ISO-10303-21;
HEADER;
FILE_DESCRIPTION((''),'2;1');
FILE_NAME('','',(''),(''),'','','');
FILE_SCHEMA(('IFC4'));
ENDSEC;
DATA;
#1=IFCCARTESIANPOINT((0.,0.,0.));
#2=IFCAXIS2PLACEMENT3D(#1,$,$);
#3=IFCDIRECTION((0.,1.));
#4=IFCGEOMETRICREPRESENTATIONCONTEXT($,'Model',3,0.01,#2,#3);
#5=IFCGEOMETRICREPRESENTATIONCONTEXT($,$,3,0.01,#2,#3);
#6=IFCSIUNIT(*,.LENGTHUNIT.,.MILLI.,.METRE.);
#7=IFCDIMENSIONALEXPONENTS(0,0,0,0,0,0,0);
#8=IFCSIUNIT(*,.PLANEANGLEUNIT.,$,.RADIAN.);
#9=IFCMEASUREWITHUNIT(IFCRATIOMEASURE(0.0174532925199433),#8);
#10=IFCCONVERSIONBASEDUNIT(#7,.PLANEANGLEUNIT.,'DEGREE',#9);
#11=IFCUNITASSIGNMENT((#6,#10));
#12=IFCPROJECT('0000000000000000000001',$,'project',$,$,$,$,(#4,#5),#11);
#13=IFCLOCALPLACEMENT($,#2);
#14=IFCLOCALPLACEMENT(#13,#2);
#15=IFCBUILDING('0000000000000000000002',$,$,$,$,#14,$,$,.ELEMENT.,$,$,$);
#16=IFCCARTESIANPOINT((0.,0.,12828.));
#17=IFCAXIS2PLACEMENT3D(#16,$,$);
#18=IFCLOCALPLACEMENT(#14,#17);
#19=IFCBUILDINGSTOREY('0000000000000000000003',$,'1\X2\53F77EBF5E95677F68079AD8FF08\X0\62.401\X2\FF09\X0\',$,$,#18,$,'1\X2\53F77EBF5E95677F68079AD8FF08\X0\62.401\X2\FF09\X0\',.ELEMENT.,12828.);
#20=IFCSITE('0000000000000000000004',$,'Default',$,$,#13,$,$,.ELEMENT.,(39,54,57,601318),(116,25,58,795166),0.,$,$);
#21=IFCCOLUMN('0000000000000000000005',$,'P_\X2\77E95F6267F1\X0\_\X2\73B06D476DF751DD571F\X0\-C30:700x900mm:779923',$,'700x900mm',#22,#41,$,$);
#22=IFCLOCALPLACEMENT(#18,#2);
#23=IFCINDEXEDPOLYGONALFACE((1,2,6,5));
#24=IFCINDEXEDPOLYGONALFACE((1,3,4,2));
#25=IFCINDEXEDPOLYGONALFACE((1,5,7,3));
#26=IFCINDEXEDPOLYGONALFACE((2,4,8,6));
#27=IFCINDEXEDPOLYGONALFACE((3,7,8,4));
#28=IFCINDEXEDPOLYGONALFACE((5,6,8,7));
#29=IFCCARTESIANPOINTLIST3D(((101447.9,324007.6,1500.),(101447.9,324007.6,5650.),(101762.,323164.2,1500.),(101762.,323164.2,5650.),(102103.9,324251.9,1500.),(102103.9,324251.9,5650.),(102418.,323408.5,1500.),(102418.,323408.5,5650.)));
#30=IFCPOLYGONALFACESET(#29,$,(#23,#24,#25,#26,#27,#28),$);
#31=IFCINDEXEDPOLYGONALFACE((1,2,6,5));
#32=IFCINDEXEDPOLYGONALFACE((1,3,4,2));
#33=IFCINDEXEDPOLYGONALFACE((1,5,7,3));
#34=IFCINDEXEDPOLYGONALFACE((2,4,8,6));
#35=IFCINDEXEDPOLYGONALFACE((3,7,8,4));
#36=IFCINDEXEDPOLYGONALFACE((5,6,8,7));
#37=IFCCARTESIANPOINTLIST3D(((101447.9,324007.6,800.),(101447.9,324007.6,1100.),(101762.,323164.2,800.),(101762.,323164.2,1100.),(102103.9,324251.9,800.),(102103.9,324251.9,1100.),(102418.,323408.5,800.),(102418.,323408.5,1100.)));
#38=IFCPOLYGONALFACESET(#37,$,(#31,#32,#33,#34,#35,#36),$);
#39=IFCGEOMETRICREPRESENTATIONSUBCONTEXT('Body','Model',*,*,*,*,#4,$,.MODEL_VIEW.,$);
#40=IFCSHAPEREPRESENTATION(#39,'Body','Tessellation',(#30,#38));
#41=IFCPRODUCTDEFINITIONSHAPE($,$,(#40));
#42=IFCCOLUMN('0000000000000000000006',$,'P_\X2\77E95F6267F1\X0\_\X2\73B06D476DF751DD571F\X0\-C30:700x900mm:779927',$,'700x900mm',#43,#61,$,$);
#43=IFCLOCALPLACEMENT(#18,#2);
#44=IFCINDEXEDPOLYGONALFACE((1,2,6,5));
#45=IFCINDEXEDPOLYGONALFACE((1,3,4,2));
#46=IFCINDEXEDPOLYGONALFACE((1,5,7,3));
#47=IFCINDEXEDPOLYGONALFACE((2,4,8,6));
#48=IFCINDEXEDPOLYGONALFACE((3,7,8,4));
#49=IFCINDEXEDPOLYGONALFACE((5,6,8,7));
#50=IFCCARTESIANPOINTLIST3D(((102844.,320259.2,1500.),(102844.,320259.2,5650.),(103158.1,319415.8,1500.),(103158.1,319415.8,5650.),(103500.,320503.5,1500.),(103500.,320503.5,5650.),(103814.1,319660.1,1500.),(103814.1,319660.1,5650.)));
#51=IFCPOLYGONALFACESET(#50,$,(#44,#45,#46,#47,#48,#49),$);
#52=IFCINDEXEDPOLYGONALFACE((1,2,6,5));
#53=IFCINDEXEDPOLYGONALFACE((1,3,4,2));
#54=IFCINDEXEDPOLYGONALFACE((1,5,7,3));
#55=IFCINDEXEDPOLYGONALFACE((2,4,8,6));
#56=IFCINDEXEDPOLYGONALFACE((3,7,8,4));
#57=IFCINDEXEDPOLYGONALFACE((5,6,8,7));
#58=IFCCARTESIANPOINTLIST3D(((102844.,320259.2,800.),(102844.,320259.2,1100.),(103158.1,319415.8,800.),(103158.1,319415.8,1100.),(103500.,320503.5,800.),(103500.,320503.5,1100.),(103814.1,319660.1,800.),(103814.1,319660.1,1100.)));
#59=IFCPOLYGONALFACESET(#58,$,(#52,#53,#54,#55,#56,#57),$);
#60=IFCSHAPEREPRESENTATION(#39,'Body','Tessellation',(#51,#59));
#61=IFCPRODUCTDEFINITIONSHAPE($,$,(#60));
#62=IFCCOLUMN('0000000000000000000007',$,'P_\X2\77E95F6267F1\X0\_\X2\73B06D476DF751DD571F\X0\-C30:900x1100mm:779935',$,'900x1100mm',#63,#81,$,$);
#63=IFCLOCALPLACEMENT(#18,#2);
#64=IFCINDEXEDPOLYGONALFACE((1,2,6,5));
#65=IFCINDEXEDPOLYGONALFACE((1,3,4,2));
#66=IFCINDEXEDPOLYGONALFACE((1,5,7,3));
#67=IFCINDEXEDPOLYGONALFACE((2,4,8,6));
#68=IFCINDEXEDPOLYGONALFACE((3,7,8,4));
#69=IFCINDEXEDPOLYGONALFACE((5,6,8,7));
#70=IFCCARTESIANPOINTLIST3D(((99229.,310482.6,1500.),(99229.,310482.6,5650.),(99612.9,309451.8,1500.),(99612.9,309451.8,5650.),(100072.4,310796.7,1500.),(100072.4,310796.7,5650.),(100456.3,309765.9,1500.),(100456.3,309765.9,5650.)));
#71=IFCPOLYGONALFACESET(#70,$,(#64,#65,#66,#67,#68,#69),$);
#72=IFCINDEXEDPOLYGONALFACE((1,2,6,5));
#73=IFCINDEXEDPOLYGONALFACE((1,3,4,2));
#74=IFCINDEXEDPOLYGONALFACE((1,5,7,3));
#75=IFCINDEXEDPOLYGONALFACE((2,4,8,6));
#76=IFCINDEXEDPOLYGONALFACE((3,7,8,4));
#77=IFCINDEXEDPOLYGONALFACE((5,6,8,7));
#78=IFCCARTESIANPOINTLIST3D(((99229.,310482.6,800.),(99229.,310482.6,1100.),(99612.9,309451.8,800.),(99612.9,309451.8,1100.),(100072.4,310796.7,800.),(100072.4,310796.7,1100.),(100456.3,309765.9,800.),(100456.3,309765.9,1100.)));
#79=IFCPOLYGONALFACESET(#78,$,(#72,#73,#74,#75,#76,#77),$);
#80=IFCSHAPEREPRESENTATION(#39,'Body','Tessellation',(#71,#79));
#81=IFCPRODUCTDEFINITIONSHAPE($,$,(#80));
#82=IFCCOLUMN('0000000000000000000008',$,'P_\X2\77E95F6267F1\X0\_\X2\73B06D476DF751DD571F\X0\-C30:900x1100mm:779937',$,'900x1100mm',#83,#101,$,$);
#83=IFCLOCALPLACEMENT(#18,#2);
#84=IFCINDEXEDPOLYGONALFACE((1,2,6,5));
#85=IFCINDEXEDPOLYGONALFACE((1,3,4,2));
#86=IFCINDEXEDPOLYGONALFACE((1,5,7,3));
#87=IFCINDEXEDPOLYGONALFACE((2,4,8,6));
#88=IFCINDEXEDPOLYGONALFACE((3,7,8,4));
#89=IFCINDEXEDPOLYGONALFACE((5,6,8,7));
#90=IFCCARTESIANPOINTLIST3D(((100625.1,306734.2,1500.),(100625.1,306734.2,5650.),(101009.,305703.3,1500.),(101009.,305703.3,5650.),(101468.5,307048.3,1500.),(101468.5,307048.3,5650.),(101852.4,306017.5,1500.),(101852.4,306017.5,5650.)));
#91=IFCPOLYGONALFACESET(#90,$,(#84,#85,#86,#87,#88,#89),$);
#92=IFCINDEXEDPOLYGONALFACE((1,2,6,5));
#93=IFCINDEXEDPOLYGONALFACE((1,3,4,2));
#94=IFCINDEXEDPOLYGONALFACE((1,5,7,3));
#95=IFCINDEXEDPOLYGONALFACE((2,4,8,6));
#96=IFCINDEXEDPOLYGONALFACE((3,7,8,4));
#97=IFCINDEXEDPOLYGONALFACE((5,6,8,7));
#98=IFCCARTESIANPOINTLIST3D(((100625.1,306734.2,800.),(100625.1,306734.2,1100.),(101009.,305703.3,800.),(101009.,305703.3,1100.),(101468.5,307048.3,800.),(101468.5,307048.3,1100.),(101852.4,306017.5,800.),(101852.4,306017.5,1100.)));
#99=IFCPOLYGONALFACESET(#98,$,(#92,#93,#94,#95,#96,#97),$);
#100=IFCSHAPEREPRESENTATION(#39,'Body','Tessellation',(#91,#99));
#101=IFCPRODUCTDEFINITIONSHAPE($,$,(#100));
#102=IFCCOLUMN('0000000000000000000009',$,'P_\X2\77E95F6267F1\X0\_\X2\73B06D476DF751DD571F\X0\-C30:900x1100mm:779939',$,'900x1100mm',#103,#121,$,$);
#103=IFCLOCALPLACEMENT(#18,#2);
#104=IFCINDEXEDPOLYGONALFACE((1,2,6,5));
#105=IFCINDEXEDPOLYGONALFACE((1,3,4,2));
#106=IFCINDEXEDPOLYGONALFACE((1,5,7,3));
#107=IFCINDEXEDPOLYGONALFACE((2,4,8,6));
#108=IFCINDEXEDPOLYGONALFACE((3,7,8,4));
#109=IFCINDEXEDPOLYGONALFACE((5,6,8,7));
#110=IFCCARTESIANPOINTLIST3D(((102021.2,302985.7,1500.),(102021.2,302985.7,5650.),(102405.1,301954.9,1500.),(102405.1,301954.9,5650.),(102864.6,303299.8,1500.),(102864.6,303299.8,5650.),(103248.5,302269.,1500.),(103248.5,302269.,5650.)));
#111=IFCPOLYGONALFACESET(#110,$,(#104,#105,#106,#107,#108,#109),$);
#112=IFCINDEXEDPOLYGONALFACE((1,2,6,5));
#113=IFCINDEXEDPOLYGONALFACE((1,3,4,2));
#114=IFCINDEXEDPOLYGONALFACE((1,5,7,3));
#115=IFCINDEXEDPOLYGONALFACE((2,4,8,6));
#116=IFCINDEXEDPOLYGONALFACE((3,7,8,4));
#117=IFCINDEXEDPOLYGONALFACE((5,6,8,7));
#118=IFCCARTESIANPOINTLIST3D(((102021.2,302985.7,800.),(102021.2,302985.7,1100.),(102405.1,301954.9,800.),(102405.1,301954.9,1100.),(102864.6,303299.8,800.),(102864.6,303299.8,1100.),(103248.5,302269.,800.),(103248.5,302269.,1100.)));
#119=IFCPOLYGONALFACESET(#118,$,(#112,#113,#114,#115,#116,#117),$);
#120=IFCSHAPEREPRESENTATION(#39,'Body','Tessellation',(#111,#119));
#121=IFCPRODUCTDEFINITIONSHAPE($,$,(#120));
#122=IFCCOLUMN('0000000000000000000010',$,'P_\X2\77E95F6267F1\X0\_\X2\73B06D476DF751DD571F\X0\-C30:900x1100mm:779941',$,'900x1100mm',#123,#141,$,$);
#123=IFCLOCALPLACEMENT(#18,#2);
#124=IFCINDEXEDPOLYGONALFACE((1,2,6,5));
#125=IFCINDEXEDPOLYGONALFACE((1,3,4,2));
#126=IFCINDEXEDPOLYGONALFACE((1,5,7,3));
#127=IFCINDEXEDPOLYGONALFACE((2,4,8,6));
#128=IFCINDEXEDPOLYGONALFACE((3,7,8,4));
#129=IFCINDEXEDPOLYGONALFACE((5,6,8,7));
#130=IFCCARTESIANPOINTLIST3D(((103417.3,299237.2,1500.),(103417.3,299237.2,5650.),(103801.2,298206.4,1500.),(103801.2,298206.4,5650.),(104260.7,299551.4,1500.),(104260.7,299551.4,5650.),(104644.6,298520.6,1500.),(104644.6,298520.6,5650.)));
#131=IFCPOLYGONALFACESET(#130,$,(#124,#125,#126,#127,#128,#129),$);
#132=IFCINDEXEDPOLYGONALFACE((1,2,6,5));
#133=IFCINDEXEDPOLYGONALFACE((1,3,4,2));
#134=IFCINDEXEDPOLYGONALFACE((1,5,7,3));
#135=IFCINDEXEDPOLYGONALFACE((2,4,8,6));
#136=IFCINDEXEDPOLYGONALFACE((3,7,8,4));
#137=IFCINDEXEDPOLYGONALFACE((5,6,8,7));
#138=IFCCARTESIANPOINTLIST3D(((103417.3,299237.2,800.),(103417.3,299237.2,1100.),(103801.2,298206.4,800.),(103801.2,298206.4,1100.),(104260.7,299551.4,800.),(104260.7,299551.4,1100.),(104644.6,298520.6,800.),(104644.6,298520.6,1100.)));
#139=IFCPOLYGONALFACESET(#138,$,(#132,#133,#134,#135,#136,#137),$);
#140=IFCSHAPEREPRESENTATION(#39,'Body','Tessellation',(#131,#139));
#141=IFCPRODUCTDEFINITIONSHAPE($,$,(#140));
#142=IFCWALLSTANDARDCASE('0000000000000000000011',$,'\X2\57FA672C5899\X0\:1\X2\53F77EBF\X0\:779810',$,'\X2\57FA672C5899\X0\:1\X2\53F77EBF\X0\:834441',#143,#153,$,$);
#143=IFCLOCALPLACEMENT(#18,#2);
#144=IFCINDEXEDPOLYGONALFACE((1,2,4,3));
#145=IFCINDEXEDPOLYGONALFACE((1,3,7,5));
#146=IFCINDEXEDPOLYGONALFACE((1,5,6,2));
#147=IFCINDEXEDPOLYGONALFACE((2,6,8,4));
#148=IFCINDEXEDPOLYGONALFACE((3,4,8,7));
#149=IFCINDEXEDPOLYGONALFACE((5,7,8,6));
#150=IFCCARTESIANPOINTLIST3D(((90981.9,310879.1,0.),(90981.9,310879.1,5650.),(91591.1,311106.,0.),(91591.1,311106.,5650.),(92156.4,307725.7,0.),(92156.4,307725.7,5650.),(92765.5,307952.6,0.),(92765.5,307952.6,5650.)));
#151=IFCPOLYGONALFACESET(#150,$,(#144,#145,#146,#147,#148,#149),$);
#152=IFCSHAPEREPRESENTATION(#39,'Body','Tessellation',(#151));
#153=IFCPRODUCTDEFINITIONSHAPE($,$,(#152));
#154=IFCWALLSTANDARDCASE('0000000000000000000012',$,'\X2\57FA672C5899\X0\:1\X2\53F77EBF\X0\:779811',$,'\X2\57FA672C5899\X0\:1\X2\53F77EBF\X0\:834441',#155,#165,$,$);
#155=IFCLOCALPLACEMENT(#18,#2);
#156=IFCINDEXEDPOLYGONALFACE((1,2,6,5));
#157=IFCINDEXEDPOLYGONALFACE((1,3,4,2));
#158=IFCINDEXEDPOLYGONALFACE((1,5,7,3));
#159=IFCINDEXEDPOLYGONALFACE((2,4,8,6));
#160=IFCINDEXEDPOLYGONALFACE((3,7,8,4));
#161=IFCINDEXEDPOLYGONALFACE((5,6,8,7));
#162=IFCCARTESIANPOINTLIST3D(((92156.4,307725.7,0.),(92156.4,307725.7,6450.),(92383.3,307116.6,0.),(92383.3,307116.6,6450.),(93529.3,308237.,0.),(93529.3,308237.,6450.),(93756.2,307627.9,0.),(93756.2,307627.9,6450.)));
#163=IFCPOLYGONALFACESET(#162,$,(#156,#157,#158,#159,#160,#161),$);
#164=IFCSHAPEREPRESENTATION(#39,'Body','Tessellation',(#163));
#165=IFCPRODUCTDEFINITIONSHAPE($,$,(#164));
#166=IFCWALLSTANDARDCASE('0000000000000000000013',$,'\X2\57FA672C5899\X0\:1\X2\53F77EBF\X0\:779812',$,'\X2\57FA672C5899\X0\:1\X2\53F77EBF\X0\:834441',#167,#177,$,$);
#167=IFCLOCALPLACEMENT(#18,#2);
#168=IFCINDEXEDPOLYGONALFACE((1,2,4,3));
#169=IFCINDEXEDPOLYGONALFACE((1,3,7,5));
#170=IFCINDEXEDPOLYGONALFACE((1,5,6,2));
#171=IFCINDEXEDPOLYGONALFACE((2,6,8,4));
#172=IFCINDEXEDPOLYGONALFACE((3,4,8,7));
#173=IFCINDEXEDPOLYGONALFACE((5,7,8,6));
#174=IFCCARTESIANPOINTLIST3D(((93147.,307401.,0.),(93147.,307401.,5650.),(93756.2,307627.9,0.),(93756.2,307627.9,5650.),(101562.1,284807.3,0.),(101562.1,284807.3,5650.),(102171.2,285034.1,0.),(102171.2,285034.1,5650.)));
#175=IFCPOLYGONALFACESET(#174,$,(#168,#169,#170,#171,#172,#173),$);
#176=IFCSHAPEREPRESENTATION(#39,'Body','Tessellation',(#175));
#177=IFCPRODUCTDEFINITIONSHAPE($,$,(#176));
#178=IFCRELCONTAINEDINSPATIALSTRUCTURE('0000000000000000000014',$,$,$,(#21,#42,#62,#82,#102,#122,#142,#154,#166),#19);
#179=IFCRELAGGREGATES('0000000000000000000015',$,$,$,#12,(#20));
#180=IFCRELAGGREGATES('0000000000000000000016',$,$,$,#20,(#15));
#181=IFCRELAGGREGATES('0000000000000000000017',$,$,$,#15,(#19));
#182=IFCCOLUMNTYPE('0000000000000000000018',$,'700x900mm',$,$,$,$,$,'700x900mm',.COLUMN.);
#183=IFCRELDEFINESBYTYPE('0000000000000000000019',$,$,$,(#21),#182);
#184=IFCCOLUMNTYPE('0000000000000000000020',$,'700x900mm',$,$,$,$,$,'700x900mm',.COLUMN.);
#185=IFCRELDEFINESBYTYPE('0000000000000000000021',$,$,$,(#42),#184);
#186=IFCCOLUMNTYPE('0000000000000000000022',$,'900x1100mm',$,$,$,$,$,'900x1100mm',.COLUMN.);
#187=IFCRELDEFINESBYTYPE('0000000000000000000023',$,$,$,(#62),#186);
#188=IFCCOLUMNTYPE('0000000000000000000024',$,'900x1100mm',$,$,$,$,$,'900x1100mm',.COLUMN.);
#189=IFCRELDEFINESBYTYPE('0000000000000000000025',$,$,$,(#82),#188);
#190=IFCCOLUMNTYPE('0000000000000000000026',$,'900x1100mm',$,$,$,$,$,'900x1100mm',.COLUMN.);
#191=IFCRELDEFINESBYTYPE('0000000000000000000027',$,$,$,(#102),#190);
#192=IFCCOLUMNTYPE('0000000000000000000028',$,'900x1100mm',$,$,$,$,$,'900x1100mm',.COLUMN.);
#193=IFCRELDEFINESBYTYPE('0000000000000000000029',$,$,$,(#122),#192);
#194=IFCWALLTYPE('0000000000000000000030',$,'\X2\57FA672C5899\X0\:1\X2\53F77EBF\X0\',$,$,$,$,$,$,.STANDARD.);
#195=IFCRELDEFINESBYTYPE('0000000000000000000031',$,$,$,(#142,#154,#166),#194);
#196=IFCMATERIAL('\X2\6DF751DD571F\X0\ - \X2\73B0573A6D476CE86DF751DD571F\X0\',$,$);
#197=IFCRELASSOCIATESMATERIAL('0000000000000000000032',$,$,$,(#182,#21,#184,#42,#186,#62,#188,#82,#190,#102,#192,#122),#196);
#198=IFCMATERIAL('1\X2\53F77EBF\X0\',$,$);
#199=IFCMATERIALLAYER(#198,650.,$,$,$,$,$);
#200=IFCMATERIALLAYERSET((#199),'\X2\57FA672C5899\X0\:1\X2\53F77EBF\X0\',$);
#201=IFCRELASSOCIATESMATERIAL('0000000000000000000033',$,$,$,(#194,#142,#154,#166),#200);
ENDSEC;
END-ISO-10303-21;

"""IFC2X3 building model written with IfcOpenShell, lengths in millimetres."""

from ifc_helpers import new_model, entity, si_unit, converted_unit, direction, frame, frame_2d, origin, origin_2d_with_axis, place, context, subcontext, project, spatial, polyline, rectangle, extrude, clip, bounded_halfspace, source, transform, mapped, material, layer, layer_set, layer_usage, type_object, type_shapes, element, save


model = new_model("IFC2X3")

# Units and contexts
model_context = context("Model", 3, precision=0.01, world=origin(), true_north=direction((0.0, 1.0)))
context_of_model = context(None, 3, precision=0.01, world=origin(), true_north=direction((0.0, 1.0)))
body_context = subcontext(model_context, "Body", "Model", "MODEL_VIEW")
ifc_project = project(units=[si_unit("LENGTHUNIT", "METRE", prefix="MILLI"), converted_unit("PLANEANGLEUNIT", "DEGREE", entity("IfcRatioMeasure", 0.0174532925199433), si_unit("PLANEANGLEUNIT", "RADIAN"), dimensions=[0, 0, 0, 0, 0, 0, 0])], contexts=[model_context, context_of_model])

# Site, building, storey
site_placement = place(None, origin())
site = spatial("IfcSite", under=ifc_project, at=site_placement, Name="Default", CompositionType="ELEMENT", RefLatitude=(39, 54, 57, 601318), RefLongitude=(116, 25, 58, 795166), RefElevation=0.0)
building_placement = place(site_placement, origin())
building = spatial("IfcBuilding", under=site, at=building_placement, CompositionType="ELEMENT")
storey_placement = place(building_placement, frame((0.0, 0.0, 12828.0)))
storey = spatial("IfcBuildingStorey", under=building, at=storey_placement, Name="1号线底板标高（62.401）", LongName="1号线底板标高（62.401）", CompositionType="ELEMENT", Elevation=12828.0)

# Columns
ifc_material_1 = material(Name="混凝土 - 现场浇注混凝土")
column_type_1 = type_object("IfcColumnType", Name="700x900mm", ElementType="700x900mm", PredefinedType="COLUMN", material=ifc_material_1)
shared_shape_1 = source(origin(), body_context, "Body", "SweptSolid", [
    extrude(rectangle(XDim=700.0, YDim=900.0, at=frame_2d((0.0, 0.0), x_axis=(1.0, 0.0))), frame((485.1, 543.9, 700.0), z_axis=(0.0, 0.0, 1.0), x_axis=(-0.937112, -0.349028, 0.0)), (0.0, 0.0, 1.0), 4150.0),
    extrude(rectangle(XDim=700.0, YDim=900.0, at=frame_2d((0.0, 0.0), x_axis=(1.0, 0.0))), frame((485.1, 543.9, 0.0), z_axis=(0.0, 0.0, 1.0), x_axis=(-0.937112, -0.349028, 0.0)), (0.0, 0.0, 1.0), 300.0),
])
type_shapes(column_type_1, [shared_shape_1])
column_1_placement = place(storey_placement, frame((101447.9, 323164.2, 800.0)))
element("IfcColumn", 1, at=column_1_placement, inside=storey, type_object=column_type_1, material=ifc_material_1, Name="P_矩形柱_现浇混凝土-C30:700x900mm:779923", ObjectType="700x900mm", context=body_context, shape_type="MappedRepresentation", body=[
    mapped(shared_shape_1, transform((0.0, 0.0, 0.0), scale=1.0)),
])
column_type_2 = type_object("IfcColumnType", Name="700x900mm", ElementType="700x900mm", PredefinedType="COLUMN", material=ifc_material_1)
shared_shape_2 = source(origin(), body_context, "Body", "SweptSolid", [
    extrude(rectangle(XDim=900.0, YDim=700.0, at=frame_2d((86.0, -70.0), x_axis=(1.0, 0.0))), frame((520.6, 648.9, 700.0), z_axis=(0.0, 0.0, 1.0), x_axis=(0.349028, -0.937112, 0.0)), (0.0, 0.0, 1.0), 4150.0),
    extrude(rectangle(XDim=900.0, YDim=700.0, at=frame_2d((0.0, 0.0), x_axis=(1.0, 0.0))), frame((485.1, 543.9, 0.0), z_axis=(0.0, 0.0, 1.0), x_axis=(0.349028, -0.937112, 0.0)), (0.0, 0.0, 1.0), 300.0),
])
type_shapes(column_type_2, [shared_shape_2])
column_2_placement = place(storey_placement, frame((102844.0, 319415.8, 800.0)))
element("IfcColumn", 2, at=column_2_placement, inside=storey, type_object=column_type_2, material=ifc_material_1, Name="P_矩形柱_现浇混凝土-C30:700x900mm:779927", ObjectType="700x900mm", context=body_context, shape_type="MappedRepresentation", body=[
    mapped(shared_shape_2, transform((0.0, 0.0, 0.0), scale=1.0)),
])
column_type_3 = type_object("IfcColumnType", Name="900x1100mm", ElementType="900x1100mm", PredefinedType="COLUMN", material=ifc_material_1)
shared_shape_3 = source(origin(), body_context, "Body", "SweptSolid", [
    extrude(rectangle(XDim=900.0, YDim=1100.0, at=origin_2d_with_axis()), frame((613.7, 672.5, 700.0), z_axis=(0.0, 0.0, 1.0), x_axis=(-0.937112, -0.349028, 0.0)), (0.0, 0.0, 1.0), 4150.0),
    extrude(rectangle(XDim=900.0, YDim=1100.0, at=origin_2d_with_axis()), frame((613.7, 672.5, 0.0), z_axis=(0.0, 0.0, 1.0), x_axis=(-0.937112, -0.349028, 0.0)), (0.0, 0.0, 1.0), 300.0),
])
type_shapes(column_type_3, [shared_shape_3])
column_3_placement = place(storey_placement, frame((99229.0, 309451.8, 800.0)))
element("IfcColumn", 3, at=column_3_placement, inside=storey, type_object=column_type_3, material=ifc_material_1, Name="P_矩形柱_现浇混凝土-C30:900x1100mm:779935", ObjectType="900x1100mm", context=body_context, shape_type="MappedRepresentation", body=[
    mapped(shared_shape_3, transform((0.0, 0.0, 0.0), scale=1.0)),
])
column_type_4 = type_object("IfcColumnType", Name="900x1100mm", ElementType="900x1100mm", PredefinedType="COLUMN", material=ifc_material_1)
shared_shape_4 = source(origin(), body_context, "Body", "SweptSolid", [
    extrude(rectangle(XDim=900.0, YDim=1100.0, at=origin_2d_with_axis()), frame((613.7, 672.5, 700.0), z_axis=(0.0, 0.0, 1.0), x_axis=(-0.937112, -0.349028, 0.0)), (0.0, 0.0, 1.0), 4150.0),
    extrude(rectangle(XDim=900.0, YDim=1100.0, at=origin_2d_with_axis()), frame((613.7, 672.5, 0.0), z_axis=(0.0, 0.0, 1.0), x_axis=(-0.937112, -0.349028, 0.0)), (0.0, 0.0, 1.0), 300.0),
])
type_shapes(column_type_4, [shared_shape_4])
column_4_placement = place(storey_placement, frame((100625.1, 305703.3, 800.0)))
element("IfcColumn", 4, at=column_4_placement, inside=storey, type_object=column_type_4, material=ifc_material_1, Name="P_矩形柱_现浇混凝土-C30:900x1100mm:779937", ObjectType="900x1100mm", context=body_context, shape_type="MappedRepresentation", body=[
    mapped(shared_shape_4, transform((0.0, 0.0, 0.0), scale=1.0)),
])
column_type_5 = type_object("IfcColumnType", Name="900x1100mm", ElementType="900x1100mm", PredefinedType="COLUMN", material=ifc_material_1)
shared_shape_5 = source(origin(), body_context, "Body", "SweptSolid", [
    extrude(rectangle(XDim=900.0, YDim=1100.0, at=frame_2d((0.0, 0.0), x_axis=(1.0, 0.0))), frame((613.7, 672.5, 700.0), z_axis=(0.0, 0.0, 1.0), x_axis=(-0.937112, -0.349028, 0.0)), (0.0, 0.0, 1.0), 4150.0),
    extrude(rectangle(XDim=900.0, YDim=1100.0, at=frame_2d((0.0, 0.0), x_axis=(1.0, 0.0))), frame((613.7, 672.5, 0.0), z_axis=(0.0, 0.0, 1.0), x_axis=(-0.937112, -0.349028, 0.0)), (0.0, 0.0, 1.0), 300.0),
])
type_shapes(column_type_5, [shared_shape_5])
column_5_placement = place(storey_placement, frame((102021.2, 301954.9, 800.0)))
element("IfcColumn", 5, at=column_5_placement, inside=storey, type_object=column_type_5, material=ifc_material_1, Name="P_矩形柱_现浇混凝土-C30:900x1100mm:779939", ObjectType="900x1100mm", context=body_context, shape_type="MappedRepresentation", body=[
    mapped(shared_shape_5, transform((0.0, 0.0, 0.0), scale=1.0)),
])
column_type_6 = type_object("IfcColumnType", Name="900x1100mm", ElementType="900x1100mm", PredefinedType="COLUMN", material=ifc_material_1)
shared_shape_6 = source(origin(), body_context, "Body", "SweptSolid", [
    extrude(rectangle(XDim=900.0, YDim=1100.0, at=frame_2d((0.0, 0.0), x_axis=(1.0, 0.0))), frame((613.7, 672.5, 700.0), z_axis=(0.0, 0.0, 1.0), x_axis=(-0.937112, -0.349028, 0.0)), (0.0, 0.0, 1.0), 4150.0),
    extrude(rectangle(XDim=900.0, YDim=1100.0, at=frame_2d((0.0, 0.0), x_axis=(1.0, 0.0))), frame((613.7, 672.5, 0.0), z_axis=(0.0, 0.0, 1.0), x_axis=(-0.937112, -0.349028, 0.0)), (0.0, 0.0, 1.0), 300.0),
])
type_shapes(column_type_6, [shared_shape_6])
column_6_placement = place(storey_placement, frame((103417.3, 298206.4, 800.0)))
element("IfcColumn", 6, at=column_6_placement, inside=storey, type_object=column_type_6, material=ifc_material_1, Name="P_矩形柱_现浇混凝土-C30:900x1100mm:779941", ObjectType="900x1100mm", context=body_context, shape_type="MappedRepresentation", body=[
    mapped(shared_shape_6, transform((0.0, 0.0, 0.0), scale=1.0)),
])

# Walls
ifc_material_2 = material(Name="1号线")
ifc_layer_1 = layer(ifc_material_2, 650.0)
ifc_layer_set_1 = layer_set([ifc_layer_1], Name="基本墙:1号线")
wall_type_1 = type_object("IfcWallType", Name="基本墙:1号线", PredefinedType="STANDARD", material=ifc_layer_set_1)
ifc_layer_usage_1 = layer_usage(ifc_layer_set_1, "AXIS2", "NEGATIVE", 325.0)
wall_1_placement = place(storey_placement, frame((91286.5, 310992.5, 0.0), z_axis=(0.0, 0.0, 1.0), x_axis=(0.349028, -0.937112, 0.0)))
element("IfcWallStandardCase", 7, at=wall_1_placement, inside=storey, type_object=wall_type_1, material=ifc_layer_usage_1, Name="基本墙:1号线:779810", ObjectType="基本墙:1号线:834441", context=body_context, shape_type="Clipping", body=[
    clip(extrude(rectangle(XDim=3365.0, YDim=650.0, at=frame_2d((1682.5, 0.0), x_axis=(-1.0, 0.0))), origin(), (0.0, 0.0, 1.0), 5650.0), bounded_halfspace(frame((0.0, -325.0, 5650.0), z_axis=(0.0, 0.0, -1.0), x_axis=(0.0, 1.0, 0.0)), True, frame((0.0, -325.0, 5650.0)), polyline([(0.0, 0.0), (3365.0, 0.0), (3365.0, 650.0), (0.0, 650.0), (0.0, 0.0)]))),
])
ifc_layer_usage_2 = layer_usage(ifc_layer_set_1, "AXIS2", "NEGATIVE", 325.0)
wall_2_placement = place(storey_placement, frame((92269.9, 307421.1, 0.0), z_axis=(0.0, 0.0, 1.0), x_axis=(0.937112, 0.349028, 0.0)))
element("IfcWallStandardCase", 8, at=wall_2_placement, inside=storey, type_object=wall_type_1, material=ifc_layer_usage_2, Name="基本墙:1号线:779811", ObjectType="基本墙:1号线:834441", context=body_context, shape_type="SweptSolid", body=[
    extrude(rectangle(XDim=1465.0, YDim=650.0, at=frame_2d((732.5, 0.0), x_axis=(-1.0, 0.0))), origin(), (0.0, 0.0, 1.0), 6450.0),
])
ifc_layer_usage_3 = layer_usage(ifc_layer_set_1, "AXIS2", "NEGATIVE", 325.0)
wall_3_placement = place(storey_placement, frame((93451.6, 307514.5, 0.0), z_axis=(0.0, 0.0, 1.0), x_axis=(0.349028, -0.937112, 0.0)))
element("IfcWallStandardCase", 9, at=wall_3_placement, inside=storey, type_object=wall_type_1, material=ifc_layer_usage_3, Name="基本墙:1号线:779812", ObjectType="基本墙:1号线:834441", context=body_context, shape_type="Clipping", body=[
    clip(extrude(rectangle(XDim=24110.0, YDim=650.0, at=frame_2d((12055.0, 0.0), x_axis=(-1.0, 0.0))), origin(), (0.0, 0.0, 1.0), 5650.0), bounded_halfspace(frame((0.0, -325.0, 5650.0), z_axis=(0.0, 0.0, -1.0), x_axis=(0.0, 1.0, 0.0)), True, frame((0.0, -325.0, 5650.0)), polyline([(0.0, 0.0), (162.5, 0.0), (24110.0, 0.0), (24110.0, 650.0), (23460.0, 650.0), (0.0, 650.0), (0.0, 0.0)]))),
])

save(model, "model.ifc")
